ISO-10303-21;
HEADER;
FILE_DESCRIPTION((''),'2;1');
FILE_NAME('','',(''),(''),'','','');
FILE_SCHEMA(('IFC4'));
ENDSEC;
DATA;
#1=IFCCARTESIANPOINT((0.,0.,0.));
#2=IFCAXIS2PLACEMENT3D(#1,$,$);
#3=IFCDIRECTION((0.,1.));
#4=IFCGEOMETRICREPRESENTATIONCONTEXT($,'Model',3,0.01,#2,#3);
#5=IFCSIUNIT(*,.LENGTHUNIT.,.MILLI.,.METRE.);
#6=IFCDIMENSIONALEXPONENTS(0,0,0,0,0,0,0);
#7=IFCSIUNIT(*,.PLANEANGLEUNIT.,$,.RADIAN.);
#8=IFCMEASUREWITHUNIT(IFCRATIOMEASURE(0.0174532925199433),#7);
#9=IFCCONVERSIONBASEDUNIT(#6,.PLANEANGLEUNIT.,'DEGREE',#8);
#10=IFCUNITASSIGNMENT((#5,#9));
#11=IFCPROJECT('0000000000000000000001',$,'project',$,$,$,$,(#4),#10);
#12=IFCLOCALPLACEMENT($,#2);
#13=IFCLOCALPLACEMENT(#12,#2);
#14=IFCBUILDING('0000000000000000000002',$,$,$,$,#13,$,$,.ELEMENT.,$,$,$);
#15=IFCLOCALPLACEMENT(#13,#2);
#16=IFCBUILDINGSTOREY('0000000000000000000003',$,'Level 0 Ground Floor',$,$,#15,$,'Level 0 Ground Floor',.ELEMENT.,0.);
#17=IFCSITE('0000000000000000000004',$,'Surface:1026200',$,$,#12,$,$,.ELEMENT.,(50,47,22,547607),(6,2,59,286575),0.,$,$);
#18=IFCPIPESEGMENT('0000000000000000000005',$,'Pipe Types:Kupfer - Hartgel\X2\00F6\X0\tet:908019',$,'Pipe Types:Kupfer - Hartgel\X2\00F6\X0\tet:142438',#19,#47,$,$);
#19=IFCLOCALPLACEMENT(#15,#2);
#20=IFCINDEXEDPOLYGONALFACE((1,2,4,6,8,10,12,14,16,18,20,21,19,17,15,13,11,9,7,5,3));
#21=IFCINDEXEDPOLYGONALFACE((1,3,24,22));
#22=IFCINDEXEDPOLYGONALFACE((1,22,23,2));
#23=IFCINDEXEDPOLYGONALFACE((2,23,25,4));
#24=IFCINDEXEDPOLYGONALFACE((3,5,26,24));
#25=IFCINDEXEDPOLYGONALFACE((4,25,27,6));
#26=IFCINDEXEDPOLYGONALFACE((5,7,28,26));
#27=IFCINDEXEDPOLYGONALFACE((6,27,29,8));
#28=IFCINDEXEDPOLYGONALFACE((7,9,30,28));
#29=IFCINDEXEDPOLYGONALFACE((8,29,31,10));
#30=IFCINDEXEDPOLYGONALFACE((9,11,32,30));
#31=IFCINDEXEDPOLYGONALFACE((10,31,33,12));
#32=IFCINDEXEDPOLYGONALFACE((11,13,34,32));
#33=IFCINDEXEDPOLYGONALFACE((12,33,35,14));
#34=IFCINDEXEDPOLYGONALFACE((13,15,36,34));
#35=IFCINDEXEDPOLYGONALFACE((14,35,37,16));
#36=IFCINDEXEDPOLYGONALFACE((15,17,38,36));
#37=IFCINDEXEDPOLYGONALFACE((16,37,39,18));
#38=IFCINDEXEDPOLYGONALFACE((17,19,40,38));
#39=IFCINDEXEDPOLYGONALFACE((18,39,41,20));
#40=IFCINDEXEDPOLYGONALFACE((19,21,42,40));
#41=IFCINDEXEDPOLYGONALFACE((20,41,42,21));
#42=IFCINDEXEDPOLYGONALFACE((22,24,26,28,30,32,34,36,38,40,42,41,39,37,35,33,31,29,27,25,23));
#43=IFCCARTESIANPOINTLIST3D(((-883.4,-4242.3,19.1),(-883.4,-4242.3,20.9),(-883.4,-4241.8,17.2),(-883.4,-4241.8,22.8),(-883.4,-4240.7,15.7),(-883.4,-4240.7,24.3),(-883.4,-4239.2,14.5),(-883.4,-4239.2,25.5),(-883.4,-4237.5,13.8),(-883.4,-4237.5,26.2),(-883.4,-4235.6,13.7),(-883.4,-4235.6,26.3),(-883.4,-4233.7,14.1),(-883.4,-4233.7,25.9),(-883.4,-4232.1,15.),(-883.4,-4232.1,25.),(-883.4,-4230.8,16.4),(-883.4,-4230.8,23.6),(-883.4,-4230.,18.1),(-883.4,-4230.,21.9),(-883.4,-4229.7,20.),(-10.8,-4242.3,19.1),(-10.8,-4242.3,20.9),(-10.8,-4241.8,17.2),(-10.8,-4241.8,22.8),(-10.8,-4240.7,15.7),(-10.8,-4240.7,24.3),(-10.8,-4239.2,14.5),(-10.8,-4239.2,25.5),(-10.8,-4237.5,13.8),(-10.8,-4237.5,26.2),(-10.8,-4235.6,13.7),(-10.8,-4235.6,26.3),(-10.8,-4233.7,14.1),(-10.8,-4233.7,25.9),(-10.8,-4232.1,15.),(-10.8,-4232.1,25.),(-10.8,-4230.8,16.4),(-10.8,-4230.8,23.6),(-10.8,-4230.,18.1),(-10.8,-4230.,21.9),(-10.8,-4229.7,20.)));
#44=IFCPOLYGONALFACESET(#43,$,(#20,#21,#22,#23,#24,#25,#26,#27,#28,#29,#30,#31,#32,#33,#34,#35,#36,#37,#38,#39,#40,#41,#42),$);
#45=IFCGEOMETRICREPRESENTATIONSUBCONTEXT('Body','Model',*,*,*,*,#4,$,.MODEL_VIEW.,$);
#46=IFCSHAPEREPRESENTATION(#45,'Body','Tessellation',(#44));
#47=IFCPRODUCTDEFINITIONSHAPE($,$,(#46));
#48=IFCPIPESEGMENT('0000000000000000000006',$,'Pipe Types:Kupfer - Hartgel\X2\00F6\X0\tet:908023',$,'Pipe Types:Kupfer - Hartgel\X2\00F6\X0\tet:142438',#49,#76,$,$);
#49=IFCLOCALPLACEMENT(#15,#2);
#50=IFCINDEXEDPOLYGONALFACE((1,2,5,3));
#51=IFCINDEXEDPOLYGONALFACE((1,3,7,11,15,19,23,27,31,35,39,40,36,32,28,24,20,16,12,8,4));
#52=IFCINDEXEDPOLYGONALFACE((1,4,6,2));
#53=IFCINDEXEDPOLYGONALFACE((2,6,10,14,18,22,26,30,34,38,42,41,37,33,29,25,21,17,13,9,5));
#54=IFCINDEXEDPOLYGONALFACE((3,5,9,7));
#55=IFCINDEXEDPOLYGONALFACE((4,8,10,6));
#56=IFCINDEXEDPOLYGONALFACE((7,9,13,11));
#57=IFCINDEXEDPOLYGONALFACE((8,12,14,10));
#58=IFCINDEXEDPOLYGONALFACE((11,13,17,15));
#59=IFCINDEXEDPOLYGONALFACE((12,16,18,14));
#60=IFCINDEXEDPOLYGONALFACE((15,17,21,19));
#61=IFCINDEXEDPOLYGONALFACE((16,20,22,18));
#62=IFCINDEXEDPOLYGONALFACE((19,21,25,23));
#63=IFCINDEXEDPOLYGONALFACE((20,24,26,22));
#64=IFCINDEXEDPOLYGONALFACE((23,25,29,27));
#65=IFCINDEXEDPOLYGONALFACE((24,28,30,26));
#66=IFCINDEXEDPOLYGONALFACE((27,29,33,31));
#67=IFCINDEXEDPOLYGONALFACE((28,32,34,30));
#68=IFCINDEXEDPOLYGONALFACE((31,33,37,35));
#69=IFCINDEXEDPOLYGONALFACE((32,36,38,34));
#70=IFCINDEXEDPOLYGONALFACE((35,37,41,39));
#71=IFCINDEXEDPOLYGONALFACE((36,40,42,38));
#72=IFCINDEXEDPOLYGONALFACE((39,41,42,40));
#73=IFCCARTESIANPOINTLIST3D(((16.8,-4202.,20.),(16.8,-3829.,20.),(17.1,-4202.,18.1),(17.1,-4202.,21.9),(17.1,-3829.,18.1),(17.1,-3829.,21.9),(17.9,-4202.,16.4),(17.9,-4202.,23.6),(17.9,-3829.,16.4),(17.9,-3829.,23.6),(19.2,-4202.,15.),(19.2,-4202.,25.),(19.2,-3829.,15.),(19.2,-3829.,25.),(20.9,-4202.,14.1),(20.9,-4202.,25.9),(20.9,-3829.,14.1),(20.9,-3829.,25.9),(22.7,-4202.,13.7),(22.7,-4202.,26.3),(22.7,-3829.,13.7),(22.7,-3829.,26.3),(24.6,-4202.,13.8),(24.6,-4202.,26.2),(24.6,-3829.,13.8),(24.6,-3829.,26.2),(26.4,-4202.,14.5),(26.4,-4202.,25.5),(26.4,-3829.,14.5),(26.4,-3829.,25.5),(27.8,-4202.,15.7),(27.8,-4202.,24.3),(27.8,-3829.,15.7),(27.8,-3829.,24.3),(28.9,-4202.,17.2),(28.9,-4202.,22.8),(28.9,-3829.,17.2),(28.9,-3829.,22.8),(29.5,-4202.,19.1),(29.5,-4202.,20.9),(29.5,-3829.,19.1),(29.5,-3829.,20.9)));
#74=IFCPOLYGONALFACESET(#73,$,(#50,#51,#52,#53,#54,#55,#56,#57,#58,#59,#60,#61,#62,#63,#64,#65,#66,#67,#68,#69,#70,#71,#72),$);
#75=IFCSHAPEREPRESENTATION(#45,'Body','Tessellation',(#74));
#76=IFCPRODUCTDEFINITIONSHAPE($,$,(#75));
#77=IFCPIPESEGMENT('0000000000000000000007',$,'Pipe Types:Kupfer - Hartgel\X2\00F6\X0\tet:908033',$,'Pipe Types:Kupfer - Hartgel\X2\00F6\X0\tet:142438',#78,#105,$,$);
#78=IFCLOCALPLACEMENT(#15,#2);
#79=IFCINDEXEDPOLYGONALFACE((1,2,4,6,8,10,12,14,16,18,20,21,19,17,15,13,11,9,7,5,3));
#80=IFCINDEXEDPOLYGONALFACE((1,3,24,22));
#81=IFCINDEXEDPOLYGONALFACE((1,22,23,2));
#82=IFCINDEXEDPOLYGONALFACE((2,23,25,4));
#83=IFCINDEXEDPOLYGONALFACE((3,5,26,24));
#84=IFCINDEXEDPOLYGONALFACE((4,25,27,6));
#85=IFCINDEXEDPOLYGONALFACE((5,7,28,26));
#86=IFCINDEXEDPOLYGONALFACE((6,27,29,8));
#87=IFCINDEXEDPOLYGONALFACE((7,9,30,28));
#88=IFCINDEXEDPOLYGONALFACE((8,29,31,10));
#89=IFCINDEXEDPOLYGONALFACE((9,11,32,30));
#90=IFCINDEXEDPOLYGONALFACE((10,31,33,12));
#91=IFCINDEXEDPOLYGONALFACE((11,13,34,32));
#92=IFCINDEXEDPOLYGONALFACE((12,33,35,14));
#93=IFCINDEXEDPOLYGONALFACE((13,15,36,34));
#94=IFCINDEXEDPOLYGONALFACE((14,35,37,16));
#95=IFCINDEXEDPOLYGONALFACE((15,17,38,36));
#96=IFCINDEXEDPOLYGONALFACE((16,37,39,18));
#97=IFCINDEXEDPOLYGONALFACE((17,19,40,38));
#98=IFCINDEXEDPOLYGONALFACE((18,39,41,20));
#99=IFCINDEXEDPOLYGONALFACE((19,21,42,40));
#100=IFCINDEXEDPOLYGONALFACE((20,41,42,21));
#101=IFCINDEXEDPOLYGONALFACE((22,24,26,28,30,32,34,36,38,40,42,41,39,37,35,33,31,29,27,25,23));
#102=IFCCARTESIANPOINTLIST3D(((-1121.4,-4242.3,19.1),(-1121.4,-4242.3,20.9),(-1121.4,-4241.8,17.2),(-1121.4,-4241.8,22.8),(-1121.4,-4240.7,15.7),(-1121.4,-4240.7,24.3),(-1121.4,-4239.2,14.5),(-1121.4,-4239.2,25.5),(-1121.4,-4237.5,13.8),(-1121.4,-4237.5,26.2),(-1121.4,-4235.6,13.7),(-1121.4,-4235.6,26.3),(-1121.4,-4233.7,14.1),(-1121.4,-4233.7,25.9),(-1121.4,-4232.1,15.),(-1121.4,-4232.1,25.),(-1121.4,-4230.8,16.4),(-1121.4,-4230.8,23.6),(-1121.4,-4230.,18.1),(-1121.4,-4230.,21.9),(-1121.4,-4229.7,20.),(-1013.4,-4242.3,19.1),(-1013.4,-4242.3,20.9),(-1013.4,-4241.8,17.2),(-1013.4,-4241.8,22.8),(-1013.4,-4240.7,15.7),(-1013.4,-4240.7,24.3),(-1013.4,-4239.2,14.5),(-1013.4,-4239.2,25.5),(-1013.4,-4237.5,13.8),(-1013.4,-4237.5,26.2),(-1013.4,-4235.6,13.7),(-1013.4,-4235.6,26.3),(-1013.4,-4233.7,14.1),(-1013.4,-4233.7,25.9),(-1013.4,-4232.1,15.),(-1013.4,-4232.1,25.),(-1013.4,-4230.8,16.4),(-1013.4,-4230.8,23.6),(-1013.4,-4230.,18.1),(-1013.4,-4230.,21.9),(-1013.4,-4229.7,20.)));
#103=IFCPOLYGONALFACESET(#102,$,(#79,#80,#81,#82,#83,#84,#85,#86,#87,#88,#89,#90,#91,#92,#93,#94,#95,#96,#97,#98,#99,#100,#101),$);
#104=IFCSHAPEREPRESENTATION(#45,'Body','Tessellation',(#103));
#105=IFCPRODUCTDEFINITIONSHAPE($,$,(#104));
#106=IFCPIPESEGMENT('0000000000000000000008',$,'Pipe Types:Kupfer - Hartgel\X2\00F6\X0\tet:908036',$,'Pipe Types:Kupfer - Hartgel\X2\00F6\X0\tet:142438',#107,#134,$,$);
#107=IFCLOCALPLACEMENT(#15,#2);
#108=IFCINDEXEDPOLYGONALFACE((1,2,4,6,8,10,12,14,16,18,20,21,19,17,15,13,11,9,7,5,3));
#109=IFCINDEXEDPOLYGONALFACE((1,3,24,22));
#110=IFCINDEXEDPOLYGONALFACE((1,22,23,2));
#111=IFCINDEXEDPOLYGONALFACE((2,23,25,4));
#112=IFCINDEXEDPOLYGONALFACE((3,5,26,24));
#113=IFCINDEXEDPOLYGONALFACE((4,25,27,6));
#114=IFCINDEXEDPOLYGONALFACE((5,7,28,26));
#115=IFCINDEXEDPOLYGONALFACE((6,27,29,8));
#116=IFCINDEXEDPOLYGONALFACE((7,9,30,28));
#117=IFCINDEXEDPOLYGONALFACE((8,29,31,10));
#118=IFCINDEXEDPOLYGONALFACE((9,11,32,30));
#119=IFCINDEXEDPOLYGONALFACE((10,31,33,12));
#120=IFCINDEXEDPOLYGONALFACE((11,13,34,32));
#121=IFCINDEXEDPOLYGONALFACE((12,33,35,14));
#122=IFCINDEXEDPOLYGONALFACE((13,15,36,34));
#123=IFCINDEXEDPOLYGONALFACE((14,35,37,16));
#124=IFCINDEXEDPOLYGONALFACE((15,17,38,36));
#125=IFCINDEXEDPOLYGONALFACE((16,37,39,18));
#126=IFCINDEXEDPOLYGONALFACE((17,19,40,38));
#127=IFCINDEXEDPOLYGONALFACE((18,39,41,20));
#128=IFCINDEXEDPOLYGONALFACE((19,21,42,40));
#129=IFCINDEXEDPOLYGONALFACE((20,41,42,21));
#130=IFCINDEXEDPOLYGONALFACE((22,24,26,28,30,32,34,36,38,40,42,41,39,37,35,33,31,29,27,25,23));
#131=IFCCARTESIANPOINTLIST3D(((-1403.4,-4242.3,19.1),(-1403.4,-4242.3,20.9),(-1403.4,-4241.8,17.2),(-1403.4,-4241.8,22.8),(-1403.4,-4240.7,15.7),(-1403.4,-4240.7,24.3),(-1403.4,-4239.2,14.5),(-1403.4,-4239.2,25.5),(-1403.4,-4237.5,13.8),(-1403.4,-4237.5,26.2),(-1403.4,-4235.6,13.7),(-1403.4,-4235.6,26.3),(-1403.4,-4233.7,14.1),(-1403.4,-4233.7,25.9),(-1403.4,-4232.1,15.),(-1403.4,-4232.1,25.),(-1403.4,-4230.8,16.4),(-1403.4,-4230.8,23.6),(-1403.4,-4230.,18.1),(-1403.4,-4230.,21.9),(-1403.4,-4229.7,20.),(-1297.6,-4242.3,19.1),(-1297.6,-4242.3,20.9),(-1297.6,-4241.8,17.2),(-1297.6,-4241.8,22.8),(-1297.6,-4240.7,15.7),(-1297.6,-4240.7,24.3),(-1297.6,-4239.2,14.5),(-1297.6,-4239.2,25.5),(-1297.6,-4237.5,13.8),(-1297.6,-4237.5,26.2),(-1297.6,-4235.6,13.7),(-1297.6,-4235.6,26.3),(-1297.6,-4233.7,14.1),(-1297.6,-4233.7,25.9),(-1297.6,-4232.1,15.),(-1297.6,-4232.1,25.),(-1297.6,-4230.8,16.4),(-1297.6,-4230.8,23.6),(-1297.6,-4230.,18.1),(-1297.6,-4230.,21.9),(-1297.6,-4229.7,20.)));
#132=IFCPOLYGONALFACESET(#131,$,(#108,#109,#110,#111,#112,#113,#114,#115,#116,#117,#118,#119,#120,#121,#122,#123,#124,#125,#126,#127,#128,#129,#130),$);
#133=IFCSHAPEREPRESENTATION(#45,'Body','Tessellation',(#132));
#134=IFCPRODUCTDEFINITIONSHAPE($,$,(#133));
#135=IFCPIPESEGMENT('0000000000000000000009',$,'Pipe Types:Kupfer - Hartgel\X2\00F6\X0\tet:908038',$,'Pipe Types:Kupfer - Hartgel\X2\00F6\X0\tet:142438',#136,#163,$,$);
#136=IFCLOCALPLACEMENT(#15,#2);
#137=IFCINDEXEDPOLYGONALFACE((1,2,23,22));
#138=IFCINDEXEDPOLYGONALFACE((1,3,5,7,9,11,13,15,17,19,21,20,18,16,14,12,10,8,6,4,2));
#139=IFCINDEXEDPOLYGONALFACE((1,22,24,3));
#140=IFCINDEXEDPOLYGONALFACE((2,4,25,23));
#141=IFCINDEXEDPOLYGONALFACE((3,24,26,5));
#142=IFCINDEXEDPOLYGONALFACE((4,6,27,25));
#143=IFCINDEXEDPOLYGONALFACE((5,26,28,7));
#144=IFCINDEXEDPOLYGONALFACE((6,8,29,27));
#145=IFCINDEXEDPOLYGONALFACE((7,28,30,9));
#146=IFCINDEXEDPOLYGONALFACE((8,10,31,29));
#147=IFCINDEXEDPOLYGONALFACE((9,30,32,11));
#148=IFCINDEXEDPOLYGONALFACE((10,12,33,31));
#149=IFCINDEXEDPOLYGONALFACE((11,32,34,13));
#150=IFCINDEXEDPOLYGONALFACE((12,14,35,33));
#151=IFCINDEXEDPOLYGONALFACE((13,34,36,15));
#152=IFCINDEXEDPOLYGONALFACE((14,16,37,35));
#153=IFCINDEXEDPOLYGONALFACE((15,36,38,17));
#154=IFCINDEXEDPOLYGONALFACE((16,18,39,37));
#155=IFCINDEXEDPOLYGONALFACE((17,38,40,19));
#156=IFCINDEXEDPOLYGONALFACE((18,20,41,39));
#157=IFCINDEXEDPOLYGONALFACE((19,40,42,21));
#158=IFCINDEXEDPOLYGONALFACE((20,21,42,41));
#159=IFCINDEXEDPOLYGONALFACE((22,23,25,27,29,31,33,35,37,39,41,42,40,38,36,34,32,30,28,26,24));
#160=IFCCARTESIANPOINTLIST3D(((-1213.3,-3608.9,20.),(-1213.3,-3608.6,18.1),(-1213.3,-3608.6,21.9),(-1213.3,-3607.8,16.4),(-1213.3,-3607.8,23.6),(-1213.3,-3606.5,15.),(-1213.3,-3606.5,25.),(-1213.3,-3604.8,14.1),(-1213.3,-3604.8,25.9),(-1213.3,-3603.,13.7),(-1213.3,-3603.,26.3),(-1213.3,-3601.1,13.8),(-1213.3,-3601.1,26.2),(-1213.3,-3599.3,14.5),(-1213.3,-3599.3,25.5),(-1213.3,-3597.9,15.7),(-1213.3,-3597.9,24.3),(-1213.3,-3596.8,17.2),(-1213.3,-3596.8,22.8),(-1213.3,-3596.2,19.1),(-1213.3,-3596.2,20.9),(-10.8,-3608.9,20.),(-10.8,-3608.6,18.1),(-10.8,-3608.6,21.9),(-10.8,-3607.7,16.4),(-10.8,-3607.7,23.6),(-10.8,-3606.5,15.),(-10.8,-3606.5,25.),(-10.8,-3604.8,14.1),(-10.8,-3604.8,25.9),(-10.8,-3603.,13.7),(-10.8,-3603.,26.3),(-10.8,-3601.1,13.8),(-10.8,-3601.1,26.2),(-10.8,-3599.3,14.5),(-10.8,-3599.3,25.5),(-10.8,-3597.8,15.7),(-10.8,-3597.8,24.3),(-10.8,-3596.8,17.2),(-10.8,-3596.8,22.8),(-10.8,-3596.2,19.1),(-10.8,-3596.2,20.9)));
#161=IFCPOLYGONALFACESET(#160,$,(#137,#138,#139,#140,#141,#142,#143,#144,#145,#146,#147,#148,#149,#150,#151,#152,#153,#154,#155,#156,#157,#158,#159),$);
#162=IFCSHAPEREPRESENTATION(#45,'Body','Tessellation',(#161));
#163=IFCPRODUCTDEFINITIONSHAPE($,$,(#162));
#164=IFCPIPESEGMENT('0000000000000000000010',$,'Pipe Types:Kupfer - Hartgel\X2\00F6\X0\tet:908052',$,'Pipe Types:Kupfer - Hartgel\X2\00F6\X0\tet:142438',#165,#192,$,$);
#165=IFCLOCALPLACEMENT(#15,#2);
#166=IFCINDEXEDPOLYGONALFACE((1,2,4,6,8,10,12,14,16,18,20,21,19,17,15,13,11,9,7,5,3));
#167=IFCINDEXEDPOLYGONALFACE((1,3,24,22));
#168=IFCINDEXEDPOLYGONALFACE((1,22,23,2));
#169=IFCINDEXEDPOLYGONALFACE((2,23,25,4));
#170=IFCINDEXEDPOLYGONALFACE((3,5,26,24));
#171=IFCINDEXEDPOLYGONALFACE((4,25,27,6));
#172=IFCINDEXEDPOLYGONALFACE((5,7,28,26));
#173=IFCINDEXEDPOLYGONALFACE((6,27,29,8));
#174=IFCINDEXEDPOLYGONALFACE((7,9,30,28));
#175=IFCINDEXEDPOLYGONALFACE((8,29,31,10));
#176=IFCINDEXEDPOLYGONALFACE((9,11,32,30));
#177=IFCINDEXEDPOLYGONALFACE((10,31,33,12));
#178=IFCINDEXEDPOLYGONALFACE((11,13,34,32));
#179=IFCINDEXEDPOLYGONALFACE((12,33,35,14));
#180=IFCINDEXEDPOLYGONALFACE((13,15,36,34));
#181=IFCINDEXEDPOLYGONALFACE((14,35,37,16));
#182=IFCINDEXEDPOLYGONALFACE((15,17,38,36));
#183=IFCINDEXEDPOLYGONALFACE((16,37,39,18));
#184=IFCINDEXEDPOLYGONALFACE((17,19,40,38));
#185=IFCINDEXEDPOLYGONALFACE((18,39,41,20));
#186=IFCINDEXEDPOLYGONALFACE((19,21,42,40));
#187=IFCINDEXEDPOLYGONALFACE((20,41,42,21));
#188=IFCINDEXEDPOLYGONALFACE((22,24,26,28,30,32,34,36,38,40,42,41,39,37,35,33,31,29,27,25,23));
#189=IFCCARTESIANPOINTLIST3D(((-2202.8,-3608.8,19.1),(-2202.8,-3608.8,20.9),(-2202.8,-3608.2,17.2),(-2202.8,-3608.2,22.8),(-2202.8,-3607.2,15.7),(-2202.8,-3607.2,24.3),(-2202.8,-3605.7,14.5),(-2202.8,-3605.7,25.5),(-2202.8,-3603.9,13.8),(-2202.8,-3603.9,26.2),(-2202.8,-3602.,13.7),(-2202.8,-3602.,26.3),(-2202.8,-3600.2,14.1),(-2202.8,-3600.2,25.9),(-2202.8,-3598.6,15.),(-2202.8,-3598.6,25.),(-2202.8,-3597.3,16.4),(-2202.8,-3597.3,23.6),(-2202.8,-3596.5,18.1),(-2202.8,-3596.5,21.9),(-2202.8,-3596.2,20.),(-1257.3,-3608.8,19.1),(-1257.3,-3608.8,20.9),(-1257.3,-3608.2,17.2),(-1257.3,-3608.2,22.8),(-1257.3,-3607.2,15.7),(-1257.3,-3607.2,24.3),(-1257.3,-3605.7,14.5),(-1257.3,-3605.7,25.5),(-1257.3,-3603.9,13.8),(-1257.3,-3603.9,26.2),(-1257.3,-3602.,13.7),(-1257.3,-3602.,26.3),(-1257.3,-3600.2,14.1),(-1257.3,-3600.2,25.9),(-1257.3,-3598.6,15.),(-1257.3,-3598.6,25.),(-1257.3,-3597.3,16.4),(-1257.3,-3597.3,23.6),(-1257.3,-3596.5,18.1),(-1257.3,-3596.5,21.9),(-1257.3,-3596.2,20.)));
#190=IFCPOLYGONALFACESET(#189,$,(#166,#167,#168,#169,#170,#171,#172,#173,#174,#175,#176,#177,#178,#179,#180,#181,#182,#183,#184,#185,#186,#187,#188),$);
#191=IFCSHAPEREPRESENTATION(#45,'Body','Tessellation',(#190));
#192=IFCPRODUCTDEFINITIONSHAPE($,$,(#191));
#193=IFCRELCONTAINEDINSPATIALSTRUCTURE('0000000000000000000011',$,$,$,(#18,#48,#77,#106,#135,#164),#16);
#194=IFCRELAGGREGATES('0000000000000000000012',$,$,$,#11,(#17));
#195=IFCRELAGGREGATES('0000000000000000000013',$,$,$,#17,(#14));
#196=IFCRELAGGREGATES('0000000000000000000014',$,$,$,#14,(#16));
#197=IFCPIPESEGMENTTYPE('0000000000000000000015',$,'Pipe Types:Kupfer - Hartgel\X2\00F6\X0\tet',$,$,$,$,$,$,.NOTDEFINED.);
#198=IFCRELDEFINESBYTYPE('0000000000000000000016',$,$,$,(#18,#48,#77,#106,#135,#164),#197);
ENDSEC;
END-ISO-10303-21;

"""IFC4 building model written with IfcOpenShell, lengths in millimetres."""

from ifc_helpers import new_model, entity, si_unit, converted_unit, direction, frame, frame_2d, origin, place, context, subcontext, project, spatial, circle, extrude, type_object, element, save


model = new_model("IFC4")

# Units and contexts
model_context = context("Model", 3, precision=0.01, world=origin(), true_north=direction((0.0, 1.0)))
body_context = subcontext(model_context, "Body", "Model", "MODEL_VIEW")
ifc_project = project(units=[si_unit("LENGTHUNIT", "METRE", prefix="MILLI"), converted_unit("PLANEANGLEUNIT", "DEGREE", entity("IfcRatioMeasure", 0.0174532925199433), si_unit("PLANEANGLEUNIT", "RADIAN"), dimensions=[0, 0, 0, 0, 0, 0, 0])], contexts=[model_context])

# Site, building, storey
site_placement = place(None, origin())
site = spatial("IfcSite", under=ifc_project, at=site_placement, Name="Surface:1026200", CompositionType="ELEMENT", RefLatitude=(50, 47, 22, 547607), RefLongitude=(6, 2, 59, 286575), RefElevation=0.0)
building_placement = place(site_placement, origin())
building = spatial("IfcBuilding", under=site, at=building_placement, CompositionType="ELEMENT")
storey_placement = place(building_placement, origin())
storey = spatial("IfcBuildingStorey", under=building, at=storey_placement, Name="Level 0 Ground Floor", LongName="Level 0 Ground Floor", CompositionType="ELEMENT", Elevation=0.0)

# Pipe segments
pipe_segment_type = type_object("IfcPipeSegmentType", Name="Pipe Types:Kupfer - Hartgelötet", PredefinedType="NOTDEFINED")
pipe_segment_1_placement = place(storey_placement, frame((-883.4, -4244.0, 12.1)))
element("IfcPipeSegment", 1, at=pipe_segment_1_placement, inside=storey, type_object=pipe_segment_type, Name="Pipe Types:Kupfer - Hartgelötet:908019", ObjectType="Pipe Types:Kupfer - Hartgelötet:142438", context=body_context, shape_type="SweptSolid", body=[
    extrude(circle(Radius=6.3, at=frame_2d((0.0, 0.0), x_axis=(1.0, 0.0))), frame((0.0, 7.9, 7.9), z_axis=(1.0, 0.0, 0.0), x_axis=(0.0, 1.0, 0.0)), (0.0, 0.0, 1.0), 872.6),
])
pipe_segment_2_placement = place(storey_placement, frame((15.2, -4202.0, 12.1)))
element("IfcPipeSegment", 2, at=pipe_segment_2_placement, inside=storey, type_object=pipe_segment_type, Name="Pipe Types:Kupfer - Hartgelötet:908023", ObjectType="Pipe Types:Kupfer - Hartgelötet:142438", context=body_context, shape_type="SweptSolid", body=[
    extrude(circle(Radius=6.3, at=frame_2d((0.0, 0.0), x_axis=(1.0, 0.0))), frame((7.9, 0.0, 7.9), z_axis=(0.0, 1.0, 0.0), x_axis=(-1.0, 0.0, 0.0)), (0.0, 0.0, 1.0), 373.0),
])
pipe_segment_3_placement = place(storey_placement, frame((-1121.4, -4244.0, 12.1)))
element("IfcPipeSegment", 3, at=pipe_segment_3_placement, inside=storey, type_object=pipe_segment_type, Name="Pipe Types:Kupfer - Hartgelötet:908033", ObjectType="Pipe Types:Kupfer - Hartgelötet:142438", context=body_context, shape_type="SweptSolid", body=[
    extrude(circle(Radius=6.3, at=frame_2d((0.0, 0.0), x_axis=(1.0, 0.0))), frame((0.0, 7.9, 7.9), z_axis=(1.0, 0.0, 0.0), x_axis=(0.0, 1.0, 0.0)), (0.0, 0.0, 1.0), 108.0),
])
pipe_segment_4_placement = place(storey_placement, frame((-1403.4, -4244.0, 12.1)))
element("IfcPipeSegment", 4, at=pipe_segment_4_placement, inside=storey, type_object=pipe_segment_type, Name="Pipe Types:Kupfer - Hartgelötet:908036", ObjectType="Pipe Types:Kupfer - Hartgelötet:142438", context=body_context, shape_type="SweptSolid", body=[
    extrude(circle(Radius=6.3, at=frame_2d((0.0, 0.0), x_axis=(1.0, 0.0))), frame((0.0, 7.9, 7.9), z_axis=(1.0, 0.0, 0.0), x_axis=(0.0, 1.0, 0.0)), (0.0, 0.0, 1.0), 105.8),
])
pipe_segment_5_placement = place(storey_placement, frame((-1213.3, -3610.5, 12.1)))
element("IfcPipeSegment", 5, at=pipe_segment_5_placement, inside=storey, type_object=pipe_segment_type, Name="Pipe Types:Kupfer - Hartgelötet:908038", ObjectType="Pipe Types:Kupfer - Hartgelötet:142438", context=body_context, shape_type="SweptSolid", body=[
    extrude(circle(Radius=6.3, at=frame_2d((0.0, 0.0), x_axis=(1.0, 0.0))), frame((0.0, 7.9, 7.9), z_axis=(1.0, 0.000017, 0.0), x_axis=(0.000017, -1.0, 0.0)), (0.0, 0.0, 1.0), 1202.5),
])
pipe_segment_6_placement = place(storey_placement, frame((-2202.8, -3610.5, 12.1)))
element("IfcPipeSegment", 6, at=pipe_segment_6_placement, inside=storey, type_object=pipe_segment_type, Name="Pipe Types:Kupfer - Hartgelötet:908052", ObjectType="Pipe Types:Kupfer - Hartgelötet:142438", context=body_context, shape_type="SweptSolid", body=[
    extrude(circle(Radius=6.3, at=frame_2d((0.0, 0.0), x_axis=(1.0, 0.0))), frame((0.0, 7.9, 7.9), z_axis=(1.0, 0.0, 0.0), x_axis=(0.0, 1.0, 0.0)), (0.0, 0.0, 1.0), 945.5),
])

save(model, "model.ifc")
